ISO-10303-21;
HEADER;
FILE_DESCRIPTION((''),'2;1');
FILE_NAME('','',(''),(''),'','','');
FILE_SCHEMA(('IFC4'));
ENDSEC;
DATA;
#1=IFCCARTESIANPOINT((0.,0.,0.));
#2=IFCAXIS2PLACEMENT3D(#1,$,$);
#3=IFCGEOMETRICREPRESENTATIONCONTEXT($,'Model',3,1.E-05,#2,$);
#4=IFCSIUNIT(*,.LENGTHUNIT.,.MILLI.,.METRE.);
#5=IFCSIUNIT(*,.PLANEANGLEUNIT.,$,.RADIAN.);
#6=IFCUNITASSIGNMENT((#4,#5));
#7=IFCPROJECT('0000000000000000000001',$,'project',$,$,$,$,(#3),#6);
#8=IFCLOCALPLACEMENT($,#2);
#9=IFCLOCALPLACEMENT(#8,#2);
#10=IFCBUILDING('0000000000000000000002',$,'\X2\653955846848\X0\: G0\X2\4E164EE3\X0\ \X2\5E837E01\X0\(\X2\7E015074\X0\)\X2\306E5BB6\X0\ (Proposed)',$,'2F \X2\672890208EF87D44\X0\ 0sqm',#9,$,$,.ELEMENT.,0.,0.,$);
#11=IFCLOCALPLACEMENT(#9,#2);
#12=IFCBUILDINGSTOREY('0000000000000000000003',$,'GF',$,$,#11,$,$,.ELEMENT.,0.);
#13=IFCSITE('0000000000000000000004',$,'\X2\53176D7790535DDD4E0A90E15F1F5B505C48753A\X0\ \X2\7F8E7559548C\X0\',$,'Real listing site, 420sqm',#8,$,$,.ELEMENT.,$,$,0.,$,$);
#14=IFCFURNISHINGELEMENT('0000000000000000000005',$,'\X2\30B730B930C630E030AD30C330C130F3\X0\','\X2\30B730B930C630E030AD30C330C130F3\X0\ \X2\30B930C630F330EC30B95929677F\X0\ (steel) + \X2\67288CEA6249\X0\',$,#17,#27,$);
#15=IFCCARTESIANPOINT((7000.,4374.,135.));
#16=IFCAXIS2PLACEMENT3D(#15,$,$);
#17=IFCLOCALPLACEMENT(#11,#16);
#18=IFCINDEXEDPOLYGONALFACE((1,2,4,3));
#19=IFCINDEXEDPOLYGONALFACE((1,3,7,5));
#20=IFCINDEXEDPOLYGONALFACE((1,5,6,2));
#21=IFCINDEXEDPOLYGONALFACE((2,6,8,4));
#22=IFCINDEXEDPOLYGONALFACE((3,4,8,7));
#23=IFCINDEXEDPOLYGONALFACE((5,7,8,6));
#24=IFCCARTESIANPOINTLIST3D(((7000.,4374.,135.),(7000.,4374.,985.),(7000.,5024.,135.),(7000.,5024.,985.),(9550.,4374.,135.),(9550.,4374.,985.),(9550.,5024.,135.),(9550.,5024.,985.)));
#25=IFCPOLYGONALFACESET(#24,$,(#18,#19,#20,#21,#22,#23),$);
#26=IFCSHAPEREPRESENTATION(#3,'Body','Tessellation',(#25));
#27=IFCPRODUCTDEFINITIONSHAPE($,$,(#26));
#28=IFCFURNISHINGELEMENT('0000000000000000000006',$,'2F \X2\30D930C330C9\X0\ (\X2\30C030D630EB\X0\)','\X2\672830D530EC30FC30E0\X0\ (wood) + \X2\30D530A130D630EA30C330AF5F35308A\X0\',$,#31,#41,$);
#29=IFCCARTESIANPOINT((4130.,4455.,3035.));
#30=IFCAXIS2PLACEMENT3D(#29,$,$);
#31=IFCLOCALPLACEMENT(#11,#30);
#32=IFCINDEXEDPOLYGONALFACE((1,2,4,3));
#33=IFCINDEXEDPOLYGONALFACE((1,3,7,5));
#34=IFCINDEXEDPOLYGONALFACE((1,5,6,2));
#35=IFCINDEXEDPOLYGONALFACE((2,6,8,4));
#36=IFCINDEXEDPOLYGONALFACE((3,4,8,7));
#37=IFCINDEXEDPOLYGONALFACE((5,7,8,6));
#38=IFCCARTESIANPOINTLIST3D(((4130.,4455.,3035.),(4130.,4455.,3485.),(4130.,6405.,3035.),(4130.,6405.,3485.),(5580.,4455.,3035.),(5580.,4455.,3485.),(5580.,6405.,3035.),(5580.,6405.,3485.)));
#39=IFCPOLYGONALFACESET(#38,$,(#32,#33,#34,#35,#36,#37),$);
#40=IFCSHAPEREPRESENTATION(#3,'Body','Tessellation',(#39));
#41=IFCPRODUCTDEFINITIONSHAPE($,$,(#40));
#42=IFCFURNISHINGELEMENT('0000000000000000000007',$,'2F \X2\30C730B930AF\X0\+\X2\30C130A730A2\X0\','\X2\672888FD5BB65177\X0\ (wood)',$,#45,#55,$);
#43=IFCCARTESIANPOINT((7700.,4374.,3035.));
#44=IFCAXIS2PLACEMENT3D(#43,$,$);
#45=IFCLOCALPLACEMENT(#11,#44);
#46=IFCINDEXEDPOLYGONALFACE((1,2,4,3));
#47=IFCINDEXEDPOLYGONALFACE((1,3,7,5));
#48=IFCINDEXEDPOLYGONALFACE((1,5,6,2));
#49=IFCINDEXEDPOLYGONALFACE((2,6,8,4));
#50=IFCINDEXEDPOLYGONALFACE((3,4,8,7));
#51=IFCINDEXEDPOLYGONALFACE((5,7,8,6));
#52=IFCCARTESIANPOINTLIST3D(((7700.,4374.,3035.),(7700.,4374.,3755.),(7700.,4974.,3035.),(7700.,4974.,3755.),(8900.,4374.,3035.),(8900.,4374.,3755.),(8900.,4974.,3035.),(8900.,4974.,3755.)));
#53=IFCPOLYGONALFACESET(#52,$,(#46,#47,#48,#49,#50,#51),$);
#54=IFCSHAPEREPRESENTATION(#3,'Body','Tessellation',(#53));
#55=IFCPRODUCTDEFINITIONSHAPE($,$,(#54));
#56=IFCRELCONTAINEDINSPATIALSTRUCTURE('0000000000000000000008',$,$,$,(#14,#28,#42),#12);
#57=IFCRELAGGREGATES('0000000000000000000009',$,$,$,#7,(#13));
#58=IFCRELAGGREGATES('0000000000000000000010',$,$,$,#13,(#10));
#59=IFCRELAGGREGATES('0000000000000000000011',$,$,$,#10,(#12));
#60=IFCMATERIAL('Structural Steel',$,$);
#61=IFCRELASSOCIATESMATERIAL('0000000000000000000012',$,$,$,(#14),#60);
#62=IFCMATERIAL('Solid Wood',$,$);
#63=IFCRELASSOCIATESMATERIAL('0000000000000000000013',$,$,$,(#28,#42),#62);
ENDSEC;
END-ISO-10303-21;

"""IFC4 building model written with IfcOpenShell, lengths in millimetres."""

from ifc_helpers import new_model, si_unit, frame, frame_2d, origin, place, context, project, spatial, rectangle, extrude, material, element, save


model = new_model("IFC4")

# Units and contexts
model_context = context("Model", 3, precision=1e-05, world=origin())
ifc_project = project(units=[si_unit("LENGTHUNIT", "METRE", prefix="MILLI"), si_unit("PLANEANGLEUNIT", "RADIAN")], contexts=[model_context])

# Site, building, storey
site_placement = place(None, origin())
site = spatial("IfcSite", under=ifc_project, at=site_placement, Name="北海道川上郡弟子屈町 美留和", ObjectType="Real listing site, 420sqm", CompositionType="ELEMENT", RefElevation=0.0)
building_placement = place(site_placement, origin())
building = spatial("IfcBuilding", under=site, at=building_placement, Name="改善案: G0世代 広縁(縁側)の家 (Proposed)", ObjectType="2F 木造軸組 0sqm", CompositionType="ELEMENT", ElevationOfRefHeight=0.0, ElevationOfTerrain=0.0)
storey_placement = place(building_placement, origin())
storey = spatial("IfcBuildingStorey", under=building, at=storey_placement, Name="GF", CompositionType="ELEMENT", Elevation=0.0)

# Shared definitions
ifc_material_1 = material(Name="Solid Wood")

# Furnishing elements
ifc_material_2 = material(Name="Structural Steel")
furnishing_1_placement = place(storey_placement, frame((7000.0, 4374.0, 135.0)))
element("IfcFurnishingElement", 1, at=furnishing_1_placement, inside=storey, material=ifc_material_2, Name="システムキッチン", Description="システムキッチン ステンレス天板 (steel) + 木質扉", context=model_context, shape_type="SweptSolid", body=[
    extrude(rectangle(XDim=2550.0, YDim=650.0, at=frame_2d((1275.0, 325.0))), frame((7000.0, 4374.0, 135.0)), (0.0, 0.0, 1.0), 850.0),
])
furnishing_2_placement = place(storey_placement, frame((4130.0, 4455.0, 3035.0)))
element("IfcFurnishingElement", 2, at=furnishing_2_placement, inside=storey, material=ifc_material_1, Name="2F ベッド (ダブル)", Description="木フレーム (wood) + ファブリック張り", context=model_context, shape_type="SweptSolid", body=[
    extrude(rectangle(XDim=1450.0, YDim=1950.0, at=frame_2d((725.0, 975.0))), frame((4130.0, 4455.0, 3035.0)), (0.0, 0.0, 1.0), 450.0),
])
furnishing_3_placement = place(storey_placement, frame((7700.0, 4374.0, 3035.0)))
element("IfcFurnishingElement", 3, at=furnishing_3_placement, inside=storey, material=ifc_material_1, Name="2F デスク+チェア", Description="木製家具 (wood)", context=model_context, shape_type="SweptSolid", body=[
    extrude(rectangle(XDim=1200.0, YDim=600.0, at=frame_2d((600.0, 300.0))), frame((7700.0, 4374.0, 3035.0)), (0.0, 0.0, 1.0), 720.0),
])

save(model, "model.ifc")
